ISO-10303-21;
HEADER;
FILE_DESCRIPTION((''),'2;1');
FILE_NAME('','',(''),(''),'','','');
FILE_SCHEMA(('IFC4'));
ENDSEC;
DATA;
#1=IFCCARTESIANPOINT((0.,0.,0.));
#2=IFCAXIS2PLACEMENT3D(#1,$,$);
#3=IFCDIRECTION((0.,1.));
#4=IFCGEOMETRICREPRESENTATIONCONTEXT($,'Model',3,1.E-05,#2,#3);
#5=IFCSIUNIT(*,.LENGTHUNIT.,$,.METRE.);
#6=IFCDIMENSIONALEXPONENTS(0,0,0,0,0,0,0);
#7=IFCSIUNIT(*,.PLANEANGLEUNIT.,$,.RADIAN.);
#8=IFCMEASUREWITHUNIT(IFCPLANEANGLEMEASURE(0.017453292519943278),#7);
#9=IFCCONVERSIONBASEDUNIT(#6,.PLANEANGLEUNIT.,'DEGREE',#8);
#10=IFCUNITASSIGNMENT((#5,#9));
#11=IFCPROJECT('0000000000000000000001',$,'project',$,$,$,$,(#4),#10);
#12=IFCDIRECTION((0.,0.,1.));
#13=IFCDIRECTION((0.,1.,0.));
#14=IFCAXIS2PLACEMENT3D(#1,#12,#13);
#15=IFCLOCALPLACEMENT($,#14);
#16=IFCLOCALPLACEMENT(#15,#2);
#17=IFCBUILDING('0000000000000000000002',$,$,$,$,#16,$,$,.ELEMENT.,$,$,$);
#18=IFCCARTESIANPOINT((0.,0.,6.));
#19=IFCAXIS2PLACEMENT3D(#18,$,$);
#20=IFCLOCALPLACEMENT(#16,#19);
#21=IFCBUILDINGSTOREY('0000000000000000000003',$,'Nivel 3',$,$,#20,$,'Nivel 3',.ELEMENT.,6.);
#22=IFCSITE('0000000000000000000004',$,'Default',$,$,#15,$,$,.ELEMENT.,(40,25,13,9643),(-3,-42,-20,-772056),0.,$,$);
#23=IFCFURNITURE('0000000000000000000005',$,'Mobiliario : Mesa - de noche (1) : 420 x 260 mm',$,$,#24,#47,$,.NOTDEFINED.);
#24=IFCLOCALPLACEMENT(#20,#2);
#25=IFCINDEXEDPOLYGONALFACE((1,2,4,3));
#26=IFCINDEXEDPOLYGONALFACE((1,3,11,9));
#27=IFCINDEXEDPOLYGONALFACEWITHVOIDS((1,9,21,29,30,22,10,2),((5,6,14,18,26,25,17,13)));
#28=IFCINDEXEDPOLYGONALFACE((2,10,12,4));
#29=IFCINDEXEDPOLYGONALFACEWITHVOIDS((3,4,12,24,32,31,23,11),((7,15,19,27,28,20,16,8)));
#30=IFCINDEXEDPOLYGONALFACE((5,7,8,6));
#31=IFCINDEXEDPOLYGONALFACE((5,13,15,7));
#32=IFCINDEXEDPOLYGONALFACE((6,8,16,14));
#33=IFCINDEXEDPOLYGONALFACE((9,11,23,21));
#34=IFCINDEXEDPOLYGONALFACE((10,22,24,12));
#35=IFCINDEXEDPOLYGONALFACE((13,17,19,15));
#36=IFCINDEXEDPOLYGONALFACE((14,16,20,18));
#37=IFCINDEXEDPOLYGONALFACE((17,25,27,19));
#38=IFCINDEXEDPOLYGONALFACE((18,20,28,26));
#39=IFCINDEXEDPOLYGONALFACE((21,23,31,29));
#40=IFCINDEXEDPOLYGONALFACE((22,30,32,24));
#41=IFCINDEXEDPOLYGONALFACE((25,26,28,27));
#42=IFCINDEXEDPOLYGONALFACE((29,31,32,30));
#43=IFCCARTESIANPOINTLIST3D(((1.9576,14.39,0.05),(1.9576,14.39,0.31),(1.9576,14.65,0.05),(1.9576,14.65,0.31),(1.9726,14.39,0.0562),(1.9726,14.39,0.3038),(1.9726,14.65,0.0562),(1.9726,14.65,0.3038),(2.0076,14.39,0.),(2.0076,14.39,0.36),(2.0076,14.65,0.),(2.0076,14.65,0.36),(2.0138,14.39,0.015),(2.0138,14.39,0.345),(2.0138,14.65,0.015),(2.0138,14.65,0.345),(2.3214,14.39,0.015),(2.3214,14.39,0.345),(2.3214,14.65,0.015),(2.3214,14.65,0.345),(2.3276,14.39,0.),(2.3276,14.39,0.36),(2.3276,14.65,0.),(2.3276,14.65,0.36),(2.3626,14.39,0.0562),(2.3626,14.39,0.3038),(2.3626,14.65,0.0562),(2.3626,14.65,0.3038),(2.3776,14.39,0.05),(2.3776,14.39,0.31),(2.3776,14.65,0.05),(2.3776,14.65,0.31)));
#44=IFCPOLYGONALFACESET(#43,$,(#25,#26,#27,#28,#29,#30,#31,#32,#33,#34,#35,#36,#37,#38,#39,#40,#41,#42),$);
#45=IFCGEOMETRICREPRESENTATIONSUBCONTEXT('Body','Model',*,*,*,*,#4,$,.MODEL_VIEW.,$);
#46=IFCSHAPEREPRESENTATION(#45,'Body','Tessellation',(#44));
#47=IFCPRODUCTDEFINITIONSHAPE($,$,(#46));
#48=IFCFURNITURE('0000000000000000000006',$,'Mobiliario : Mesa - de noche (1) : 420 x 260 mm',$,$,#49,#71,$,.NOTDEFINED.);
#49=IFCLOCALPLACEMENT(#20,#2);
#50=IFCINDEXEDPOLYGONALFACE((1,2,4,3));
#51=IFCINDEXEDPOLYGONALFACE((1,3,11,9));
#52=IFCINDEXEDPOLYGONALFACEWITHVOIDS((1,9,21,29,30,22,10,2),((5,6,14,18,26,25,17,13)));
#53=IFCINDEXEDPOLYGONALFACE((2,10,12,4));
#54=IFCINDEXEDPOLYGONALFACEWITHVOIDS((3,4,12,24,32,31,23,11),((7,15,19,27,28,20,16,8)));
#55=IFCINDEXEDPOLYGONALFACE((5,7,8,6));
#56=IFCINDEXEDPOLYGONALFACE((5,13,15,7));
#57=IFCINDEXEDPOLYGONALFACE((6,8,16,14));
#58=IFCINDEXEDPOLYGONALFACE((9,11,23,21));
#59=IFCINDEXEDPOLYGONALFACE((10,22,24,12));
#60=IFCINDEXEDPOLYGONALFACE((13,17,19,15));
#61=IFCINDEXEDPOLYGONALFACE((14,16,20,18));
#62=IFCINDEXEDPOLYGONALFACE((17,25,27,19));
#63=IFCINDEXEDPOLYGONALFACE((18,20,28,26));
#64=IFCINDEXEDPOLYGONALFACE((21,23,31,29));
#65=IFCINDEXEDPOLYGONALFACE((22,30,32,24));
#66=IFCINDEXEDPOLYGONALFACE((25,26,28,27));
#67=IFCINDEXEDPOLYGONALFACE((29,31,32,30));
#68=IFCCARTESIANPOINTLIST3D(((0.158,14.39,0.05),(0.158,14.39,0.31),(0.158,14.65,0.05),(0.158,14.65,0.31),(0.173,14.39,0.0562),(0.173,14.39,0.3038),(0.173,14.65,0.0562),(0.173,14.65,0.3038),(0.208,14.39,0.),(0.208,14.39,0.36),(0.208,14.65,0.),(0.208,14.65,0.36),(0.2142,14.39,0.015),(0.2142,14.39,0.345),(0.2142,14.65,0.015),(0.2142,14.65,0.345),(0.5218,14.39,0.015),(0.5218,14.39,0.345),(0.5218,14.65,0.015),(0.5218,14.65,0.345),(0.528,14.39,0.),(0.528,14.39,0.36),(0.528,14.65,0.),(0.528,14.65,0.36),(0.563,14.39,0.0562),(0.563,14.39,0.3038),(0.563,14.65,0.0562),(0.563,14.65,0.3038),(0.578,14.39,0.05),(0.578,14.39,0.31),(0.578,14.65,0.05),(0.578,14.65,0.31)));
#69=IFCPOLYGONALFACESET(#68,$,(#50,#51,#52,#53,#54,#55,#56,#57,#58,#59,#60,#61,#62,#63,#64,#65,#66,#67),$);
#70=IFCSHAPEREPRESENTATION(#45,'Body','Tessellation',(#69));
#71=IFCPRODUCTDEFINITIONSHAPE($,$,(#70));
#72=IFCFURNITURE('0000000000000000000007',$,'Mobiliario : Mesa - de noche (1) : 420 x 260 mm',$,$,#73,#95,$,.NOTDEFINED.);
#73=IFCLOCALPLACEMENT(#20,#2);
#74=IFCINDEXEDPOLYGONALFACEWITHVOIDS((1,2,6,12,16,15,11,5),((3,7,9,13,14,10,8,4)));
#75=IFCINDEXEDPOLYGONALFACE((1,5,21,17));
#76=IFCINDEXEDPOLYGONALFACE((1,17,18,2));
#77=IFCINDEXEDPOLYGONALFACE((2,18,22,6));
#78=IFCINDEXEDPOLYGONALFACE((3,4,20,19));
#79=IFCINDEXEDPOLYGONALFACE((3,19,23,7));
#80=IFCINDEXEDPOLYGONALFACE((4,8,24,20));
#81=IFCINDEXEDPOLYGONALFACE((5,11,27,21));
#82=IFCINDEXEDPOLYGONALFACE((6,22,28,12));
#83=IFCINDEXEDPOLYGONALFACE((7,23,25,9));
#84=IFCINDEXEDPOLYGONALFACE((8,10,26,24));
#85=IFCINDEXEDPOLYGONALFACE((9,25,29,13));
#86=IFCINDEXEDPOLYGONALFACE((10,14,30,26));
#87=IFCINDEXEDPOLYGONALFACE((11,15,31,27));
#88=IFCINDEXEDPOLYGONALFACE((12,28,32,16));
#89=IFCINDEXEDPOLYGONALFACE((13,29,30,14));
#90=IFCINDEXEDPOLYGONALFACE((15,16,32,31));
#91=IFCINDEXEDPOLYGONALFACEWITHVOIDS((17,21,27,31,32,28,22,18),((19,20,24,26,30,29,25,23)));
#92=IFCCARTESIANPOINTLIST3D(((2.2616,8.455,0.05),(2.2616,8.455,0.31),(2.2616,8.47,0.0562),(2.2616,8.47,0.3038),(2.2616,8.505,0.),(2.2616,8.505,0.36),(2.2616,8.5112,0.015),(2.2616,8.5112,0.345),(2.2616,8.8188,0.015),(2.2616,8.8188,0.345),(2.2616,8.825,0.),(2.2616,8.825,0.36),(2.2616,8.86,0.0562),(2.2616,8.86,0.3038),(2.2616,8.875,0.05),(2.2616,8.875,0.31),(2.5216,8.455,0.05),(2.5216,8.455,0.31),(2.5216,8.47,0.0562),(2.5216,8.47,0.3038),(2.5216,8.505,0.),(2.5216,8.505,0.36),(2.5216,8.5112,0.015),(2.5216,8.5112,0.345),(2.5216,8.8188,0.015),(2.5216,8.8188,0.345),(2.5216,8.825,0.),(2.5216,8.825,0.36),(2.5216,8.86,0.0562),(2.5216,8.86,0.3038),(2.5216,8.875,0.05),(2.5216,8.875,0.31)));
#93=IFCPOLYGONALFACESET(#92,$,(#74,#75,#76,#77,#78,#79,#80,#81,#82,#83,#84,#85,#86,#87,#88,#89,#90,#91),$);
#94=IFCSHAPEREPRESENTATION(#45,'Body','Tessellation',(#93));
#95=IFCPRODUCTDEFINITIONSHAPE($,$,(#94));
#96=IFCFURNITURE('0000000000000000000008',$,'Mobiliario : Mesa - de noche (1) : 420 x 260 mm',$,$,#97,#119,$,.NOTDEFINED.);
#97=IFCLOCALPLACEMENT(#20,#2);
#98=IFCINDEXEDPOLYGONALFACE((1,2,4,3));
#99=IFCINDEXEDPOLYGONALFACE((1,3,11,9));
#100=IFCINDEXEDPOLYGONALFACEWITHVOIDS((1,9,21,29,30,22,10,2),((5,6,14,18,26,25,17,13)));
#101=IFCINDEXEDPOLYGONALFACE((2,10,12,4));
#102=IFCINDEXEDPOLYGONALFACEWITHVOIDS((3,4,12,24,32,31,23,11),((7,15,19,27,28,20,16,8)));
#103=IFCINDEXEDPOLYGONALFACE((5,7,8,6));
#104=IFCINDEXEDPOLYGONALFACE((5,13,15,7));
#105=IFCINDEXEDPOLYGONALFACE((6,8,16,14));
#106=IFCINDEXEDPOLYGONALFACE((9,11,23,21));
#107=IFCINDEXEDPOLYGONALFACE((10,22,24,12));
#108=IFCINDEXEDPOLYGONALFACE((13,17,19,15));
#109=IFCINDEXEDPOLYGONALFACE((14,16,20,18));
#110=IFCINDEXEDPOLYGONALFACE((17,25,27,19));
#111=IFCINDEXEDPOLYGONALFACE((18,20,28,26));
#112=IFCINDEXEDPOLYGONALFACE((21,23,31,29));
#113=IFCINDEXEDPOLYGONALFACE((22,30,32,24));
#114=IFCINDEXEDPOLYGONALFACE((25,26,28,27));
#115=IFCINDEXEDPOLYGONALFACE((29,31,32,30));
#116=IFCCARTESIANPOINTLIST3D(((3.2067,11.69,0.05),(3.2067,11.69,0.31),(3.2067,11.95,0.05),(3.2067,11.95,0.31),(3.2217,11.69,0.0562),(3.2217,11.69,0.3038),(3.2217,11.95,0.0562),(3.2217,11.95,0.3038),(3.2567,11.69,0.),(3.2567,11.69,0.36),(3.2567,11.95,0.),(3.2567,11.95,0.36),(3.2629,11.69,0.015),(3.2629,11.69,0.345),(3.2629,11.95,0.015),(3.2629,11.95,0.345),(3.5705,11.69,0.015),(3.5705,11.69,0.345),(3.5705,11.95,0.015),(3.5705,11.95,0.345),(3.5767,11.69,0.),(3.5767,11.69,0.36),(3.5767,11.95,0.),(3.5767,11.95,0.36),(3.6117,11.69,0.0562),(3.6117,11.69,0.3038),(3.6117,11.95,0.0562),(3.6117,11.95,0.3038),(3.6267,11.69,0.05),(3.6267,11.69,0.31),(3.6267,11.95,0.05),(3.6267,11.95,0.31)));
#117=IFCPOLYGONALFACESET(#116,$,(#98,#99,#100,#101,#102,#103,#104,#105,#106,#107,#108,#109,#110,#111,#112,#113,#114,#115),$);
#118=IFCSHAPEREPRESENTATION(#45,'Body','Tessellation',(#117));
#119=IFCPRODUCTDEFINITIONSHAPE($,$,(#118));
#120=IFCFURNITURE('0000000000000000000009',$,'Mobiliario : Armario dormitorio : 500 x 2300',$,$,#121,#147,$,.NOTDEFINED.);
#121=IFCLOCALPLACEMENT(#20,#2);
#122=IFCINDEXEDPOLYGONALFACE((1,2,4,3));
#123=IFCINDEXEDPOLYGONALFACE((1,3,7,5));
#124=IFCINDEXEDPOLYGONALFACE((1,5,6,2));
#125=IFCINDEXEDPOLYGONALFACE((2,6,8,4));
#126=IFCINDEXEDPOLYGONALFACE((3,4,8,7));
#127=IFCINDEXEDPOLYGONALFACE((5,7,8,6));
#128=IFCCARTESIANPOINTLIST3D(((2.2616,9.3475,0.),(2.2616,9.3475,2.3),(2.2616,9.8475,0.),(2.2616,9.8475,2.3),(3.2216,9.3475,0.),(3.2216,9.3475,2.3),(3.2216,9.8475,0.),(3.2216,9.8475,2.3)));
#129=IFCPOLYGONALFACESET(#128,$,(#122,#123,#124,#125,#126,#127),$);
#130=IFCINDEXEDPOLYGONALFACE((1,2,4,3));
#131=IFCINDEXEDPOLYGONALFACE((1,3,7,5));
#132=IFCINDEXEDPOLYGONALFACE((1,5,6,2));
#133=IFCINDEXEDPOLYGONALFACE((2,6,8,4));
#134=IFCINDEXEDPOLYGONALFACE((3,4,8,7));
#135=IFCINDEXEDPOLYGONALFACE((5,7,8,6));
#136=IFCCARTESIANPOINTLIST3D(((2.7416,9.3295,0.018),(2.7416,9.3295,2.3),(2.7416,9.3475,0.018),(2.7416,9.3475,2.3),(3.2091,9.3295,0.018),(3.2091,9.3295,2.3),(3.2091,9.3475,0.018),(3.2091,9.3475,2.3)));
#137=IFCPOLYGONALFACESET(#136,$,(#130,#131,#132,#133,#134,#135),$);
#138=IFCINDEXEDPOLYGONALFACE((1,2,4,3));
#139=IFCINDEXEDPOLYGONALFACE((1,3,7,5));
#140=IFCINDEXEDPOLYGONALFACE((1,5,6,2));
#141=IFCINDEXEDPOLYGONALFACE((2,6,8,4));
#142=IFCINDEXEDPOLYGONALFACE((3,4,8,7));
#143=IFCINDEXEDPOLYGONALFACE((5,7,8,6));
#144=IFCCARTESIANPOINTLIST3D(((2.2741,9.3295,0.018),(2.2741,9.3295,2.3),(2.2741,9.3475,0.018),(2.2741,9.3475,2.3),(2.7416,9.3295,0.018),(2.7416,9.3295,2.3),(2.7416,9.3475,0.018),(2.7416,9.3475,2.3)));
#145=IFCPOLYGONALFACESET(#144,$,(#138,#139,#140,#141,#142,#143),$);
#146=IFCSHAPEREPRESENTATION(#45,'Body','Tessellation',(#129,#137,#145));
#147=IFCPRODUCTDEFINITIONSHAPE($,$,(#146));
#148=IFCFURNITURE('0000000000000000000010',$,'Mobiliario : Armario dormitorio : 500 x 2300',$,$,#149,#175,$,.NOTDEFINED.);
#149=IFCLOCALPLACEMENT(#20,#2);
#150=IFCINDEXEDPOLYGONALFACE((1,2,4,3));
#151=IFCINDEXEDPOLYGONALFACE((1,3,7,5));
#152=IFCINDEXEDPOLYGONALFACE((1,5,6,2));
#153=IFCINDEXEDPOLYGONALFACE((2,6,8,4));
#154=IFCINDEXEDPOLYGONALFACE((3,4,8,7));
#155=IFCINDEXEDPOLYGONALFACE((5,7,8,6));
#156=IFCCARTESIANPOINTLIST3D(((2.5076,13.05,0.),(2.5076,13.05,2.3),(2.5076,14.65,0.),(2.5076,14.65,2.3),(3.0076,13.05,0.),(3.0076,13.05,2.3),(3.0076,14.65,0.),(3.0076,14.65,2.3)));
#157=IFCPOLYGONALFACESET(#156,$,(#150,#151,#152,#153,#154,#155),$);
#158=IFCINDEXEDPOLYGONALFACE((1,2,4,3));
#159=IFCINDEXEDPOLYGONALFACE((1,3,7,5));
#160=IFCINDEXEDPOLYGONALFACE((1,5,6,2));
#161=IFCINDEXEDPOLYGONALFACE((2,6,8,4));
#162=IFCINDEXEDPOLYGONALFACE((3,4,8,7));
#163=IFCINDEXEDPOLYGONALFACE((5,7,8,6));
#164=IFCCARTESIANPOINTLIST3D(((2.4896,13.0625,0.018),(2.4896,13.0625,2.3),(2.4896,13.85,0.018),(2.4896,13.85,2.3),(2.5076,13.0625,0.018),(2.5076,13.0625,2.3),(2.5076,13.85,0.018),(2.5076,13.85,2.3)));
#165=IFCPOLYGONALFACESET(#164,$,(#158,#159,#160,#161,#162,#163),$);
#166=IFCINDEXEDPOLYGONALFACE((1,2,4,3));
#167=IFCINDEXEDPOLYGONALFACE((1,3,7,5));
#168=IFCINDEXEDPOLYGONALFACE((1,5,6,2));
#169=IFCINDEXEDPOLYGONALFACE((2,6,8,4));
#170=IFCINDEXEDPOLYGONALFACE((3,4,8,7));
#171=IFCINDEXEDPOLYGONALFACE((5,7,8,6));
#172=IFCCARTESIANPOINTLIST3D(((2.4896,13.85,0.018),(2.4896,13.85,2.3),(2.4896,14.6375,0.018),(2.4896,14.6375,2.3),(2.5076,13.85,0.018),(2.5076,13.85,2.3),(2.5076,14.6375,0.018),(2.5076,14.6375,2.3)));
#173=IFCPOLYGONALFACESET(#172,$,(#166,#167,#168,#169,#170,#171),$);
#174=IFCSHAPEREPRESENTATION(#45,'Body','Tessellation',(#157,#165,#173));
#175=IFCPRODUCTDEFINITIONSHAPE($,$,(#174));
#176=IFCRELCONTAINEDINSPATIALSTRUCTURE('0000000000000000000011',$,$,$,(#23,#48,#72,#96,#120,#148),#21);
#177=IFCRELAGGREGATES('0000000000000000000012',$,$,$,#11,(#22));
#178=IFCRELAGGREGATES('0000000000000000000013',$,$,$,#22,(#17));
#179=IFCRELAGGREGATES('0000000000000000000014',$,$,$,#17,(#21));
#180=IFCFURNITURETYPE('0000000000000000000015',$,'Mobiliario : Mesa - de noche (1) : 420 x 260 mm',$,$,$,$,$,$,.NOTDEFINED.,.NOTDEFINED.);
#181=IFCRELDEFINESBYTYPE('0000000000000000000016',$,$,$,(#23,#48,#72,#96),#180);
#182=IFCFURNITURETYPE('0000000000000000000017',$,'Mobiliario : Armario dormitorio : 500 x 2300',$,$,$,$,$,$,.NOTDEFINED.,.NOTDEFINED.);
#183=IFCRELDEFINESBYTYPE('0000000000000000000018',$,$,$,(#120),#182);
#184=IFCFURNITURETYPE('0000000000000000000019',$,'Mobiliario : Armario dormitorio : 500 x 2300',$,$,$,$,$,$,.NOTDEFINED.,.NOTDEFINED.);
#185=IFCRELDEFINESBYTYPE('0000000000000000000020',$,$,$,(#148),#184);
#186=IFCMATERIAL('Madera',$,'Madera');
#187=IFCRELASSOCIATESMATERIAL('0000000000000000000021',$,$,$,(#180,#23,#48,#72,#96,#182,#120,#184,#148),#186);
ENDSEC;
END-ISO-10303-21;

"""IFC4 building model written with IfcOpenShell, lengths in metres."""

from ifc_helpers import new_model, entity, si_unit, converted_unit, direction, frame, origin, place, context, subcontext, project, spatial, indexed_curve, outline, extrude, source, transform, mapped, material, type_object, type_shapes, element, save


model = new_model("IFC4")

# Units and contexts
model_context = context("Model", 3, precision=1e-05, world=origin(), true_north=direction((0.0, 1.0)))
body_context = subcontext(model_context, "Body", "Model", "MODEL_VIEW")
ifc_project = project(units=[si_unit("LENGTHUNIT", "METRE"), converted_unit("PLANEANGLEUNIT", "DEGREE", entity("IfcPlaneAngleMeasure", 0.017453292519943278), si_unit("PLANEANGLEUNIT", "RADIAN"), dimensions=[0, 0, 0, 0, 0, 0, 0])], contexts=[model_context])

# Site, building, storey
site_placement = place(None, frame((0.0, 0.0, 0.0), z_axis=(0.0, 0.0, 1.0), x_axis=(0.0, 1.0, 0.0)))
site = spatial("IfcSite", under=ifc_project, at=site_placement, Name="Default", CompositionType="ELEMENT", RefLatitude=(40, 25, 13, 9643), RefLongitude=(-3, -42, -20, -772056), RefElevation=0.0)
building_placement = place(site_placement, origin())
building = spatial("IfcBuilding", under=site, at=building_placement, CompositionType="ELEMENT")
storey_placement = place(building_placement, frame((0.0, 0.0, 6.0)))
storey = spatial("IfcBuildingStorey", under=building, at=storey_placement, Name="Nivel 3", LongName="Nivel 3", CompositionType="ELEMENT", Elevation=6.0)

# Furniture
ifc_material_1 = material(Name="Madera", Category="Madera")
furniture_type_1 = type_object("IfcFurnitureType", Name="Mobiliario : Mesa - de noche (1) : 420 x 260 mm", AssemblyPlace="NOTDEFINED", PredefinedType="NOTDEFINED", material=ifc_material_1)
shared_shape_1 = source(origin(), body_context, "Body", "SweptSolid", [
    extrude(outline(indexed_curve([(-0.16, -0.18), (0.16, -0.18), (0.21, -0.13), (0.21, 0.13), (0.16, 0.18), (-0.16, 0.18), (-0.21, 0.13), (-0.21, -0.13), (-0.16, -0.18)], self_intersect=False), holes=[indexed_curve([(-0.1538, -0.165), (-0.195, -0.1238), (-0.195, 0.1238), (-0.1538, 0.165), (0.1538, 0.165), (0.195, 0.1238), (0.195, -0.1238), (0.1538, -0.165), (-0.1538, -0.165)], self_intersect=False)]), frame((0.0, 0.0, 0.18), z_axis=(0.0, 1.0, 0.0), x_axis=(-1.0, 0.0, 0.0)), (0.0, 0.0, 1.0), 0.26),
])
type_shapes(furniture_type_1, [shared_shape_1])
for number, where, z_axis, x_axis, name in (
    (1, (2.1676, 14.65, 0.0), (0.0, 0.0, 1.0), (-1.0, 0.0, 0.0), "Mobiliario : Mesa - de noche (1) : 420 x 260 mm"),
    (2, (0.368, 14.65, 0.0), (0.0, 0.0, 1.0), (-1.0, 0.0, 0.0), "Mobiliario : Mesa - de noche (1) : 420 x 260 mm"),
    (3, (2.2616, 8.665, 0.0), (0.0, 0.0, 1.0), (0.0, -1.0, 0.0), "Mobiliario : Mesa - de noche (1) : 420 x 260 mm"),
    (4, (3.4167, 11.95, 0.0), (0.0, 0.0, 1.0), (-1.0, 0.0, 0.0), "Mobiliario : Mesa - de noche (1) : 420 x 260 mm"),
):
    element("IfcFurniture", number, at=place(storey_placement, frame(where, z_axis=z_axis, x_axis=x_axis)), inside=storey, type_object=furniture_type_1, material=ifc_material_1, Name=name, PredefinedType="NOTDEFINED", context=body_context, shape_type="MappedRepresentation", body=[
        mapped(shared_shape_1, transform((0.0, 0.0, 0.0), scale=1.0)),
    ])
furniture_type_2 = type_object("IfcFurnitureType", Name="Mobiliario : Armario dormitorio : 500 x 2300", AssemblyPlace="NOTDEFINED", PredefinedType="NOTDEFINED", material=ifc_material_1)
shared_shape_2 = source(origin(), body_context, "Body", "SweptSolid", [
    extrude(outline(indexed_curve([(-0.25, -0.48), (0.25, -0.48), (0.25, 0.48), (-0.25, 0.48), (-0.25, -0.48)], self_intersect=False)), frame((0.0, 0.25, 0.0), z_axis=(0.0, 0.0, 1.0), x_axis=(0.0, 1.0, 0.0)), (0.0, 0.0, 1.0), 2.3),
    extrude(outline(indexed_curve([(-0.009, -0.2337), (0.009, -0.2337), (0.009, 0.2337), (-0.009, 0.2337), (-0.009, -0.2337)], self_intersect=False)), frame((-0.2337, 0.509, 0.018), z_axis=(0.0, 0.0, 1.0), x_axis=(0.0, 1.0, 0.0)), (0.0, 0.0, 1.0), 2.282),
    extrude(outline(indexed_curve([(-0.2337, -0.009), (0.2337, -0.009), (0.2337, 0.009), (-0.2337, 0.009), (-0.2337, -0.009)], self_intersect=False)), frame((0.2337, 0.509, 0.018)), (0.0, 0.0, 1.0), 2.282),
])
type_shapes(furniture_type_2, [shared_shape_2])
furniture_1_placement = place(storey_placement, frame((2.7416, 9.8475, 0.0), z_axis=(0.0, 0.0, 1.0), x_axis=(-1.0, 0.0, 0.0)))
element("IfcFurniture", 5, at=furniture_1_placement, inside=storey, type_object=furniture_type_2, material=ifc_material_1, Name="Mobiliario : Armario dormitorio : 500 x 2300", PredefinedType="NOTDEFINED", context=body_context, shape_type="MappedRepresentation", body=[
    mapped(shared_shape_2, transform((0.0, 0.0, 0.0), scale=1.0)),
])
furniture_type_3 = type_object("IfcFurnitureType", Name="Mobiliario : Armario dormitorio : 500 x 2300", AssemblyPlace="NOTDEFINED", PredefinedType="NOTDEFINED", material=ifc_material_1)
shared_shape_3 = source(origin(), body_context, "Body", "SweptSolid", [
    extrude(outline(indexed_curve([(-0.25, -0.8), (0.25, -0.8), (0.25, 0.8), (-0.25, 0.8), (-0.25, -0.8)], self_intersect=False)), frame((0.0, 0.25, 0.0), z_axis=(0.0, 0.0, 1.0), x_axis=(0.0, 1.0, 0.0)), (0.0, 0.0, 1.0), 2.3),
    extrude(outline(indexed_curve([(-0.009, -0.3937), (0.009, -0.3937), (0.009, 0.3937), (-0.009, 0.3937), (-0.009, -0.3937)], self_intersect=False)), frame((-0.3937, 0.509, 0.018), z_axis=(0.0, 0.0, 1.0), x_axis=(0.0, 1.0, 0.0)), (0.0, 0.0, 1.0), 2.282),
    extrude(outline(indexed_curve([(-0.3937, -0.009), (0.3937, -0.009), (0.3937, 0.009), (-0.3937, 0.009), (-0.3937, -0.009)], self_intersect=False)), frame((0.3937, 0.509, 0.018)), (0.0, 0.0, 1.0), 2.282),
])
type_shapes(furniture_type_3, [shared_shape_3])
furniture_2_placement = place(storey_placement, frame((3.0076, 13.85, 0.0), z_axis=(0.0, 0.0, 1.0), x_axis=(0.0, 1.0, 0.0)))
element("IfcFurniture", 6, at=furniture_2_placement, inside=storey, type_object=furniture_type_3, material=ifc_material_1, Name="Mobiliario : Armario dormitorio : 500 x 2300", PredefinedType="NOTDEFINED", context=body_context, shape_type="MappedRepresentation", body=[
    mapped(shared_shape_3, transform((0.0, 0.0, 0.0), scale=1.0)),
])

save(model, "model.ifc")
